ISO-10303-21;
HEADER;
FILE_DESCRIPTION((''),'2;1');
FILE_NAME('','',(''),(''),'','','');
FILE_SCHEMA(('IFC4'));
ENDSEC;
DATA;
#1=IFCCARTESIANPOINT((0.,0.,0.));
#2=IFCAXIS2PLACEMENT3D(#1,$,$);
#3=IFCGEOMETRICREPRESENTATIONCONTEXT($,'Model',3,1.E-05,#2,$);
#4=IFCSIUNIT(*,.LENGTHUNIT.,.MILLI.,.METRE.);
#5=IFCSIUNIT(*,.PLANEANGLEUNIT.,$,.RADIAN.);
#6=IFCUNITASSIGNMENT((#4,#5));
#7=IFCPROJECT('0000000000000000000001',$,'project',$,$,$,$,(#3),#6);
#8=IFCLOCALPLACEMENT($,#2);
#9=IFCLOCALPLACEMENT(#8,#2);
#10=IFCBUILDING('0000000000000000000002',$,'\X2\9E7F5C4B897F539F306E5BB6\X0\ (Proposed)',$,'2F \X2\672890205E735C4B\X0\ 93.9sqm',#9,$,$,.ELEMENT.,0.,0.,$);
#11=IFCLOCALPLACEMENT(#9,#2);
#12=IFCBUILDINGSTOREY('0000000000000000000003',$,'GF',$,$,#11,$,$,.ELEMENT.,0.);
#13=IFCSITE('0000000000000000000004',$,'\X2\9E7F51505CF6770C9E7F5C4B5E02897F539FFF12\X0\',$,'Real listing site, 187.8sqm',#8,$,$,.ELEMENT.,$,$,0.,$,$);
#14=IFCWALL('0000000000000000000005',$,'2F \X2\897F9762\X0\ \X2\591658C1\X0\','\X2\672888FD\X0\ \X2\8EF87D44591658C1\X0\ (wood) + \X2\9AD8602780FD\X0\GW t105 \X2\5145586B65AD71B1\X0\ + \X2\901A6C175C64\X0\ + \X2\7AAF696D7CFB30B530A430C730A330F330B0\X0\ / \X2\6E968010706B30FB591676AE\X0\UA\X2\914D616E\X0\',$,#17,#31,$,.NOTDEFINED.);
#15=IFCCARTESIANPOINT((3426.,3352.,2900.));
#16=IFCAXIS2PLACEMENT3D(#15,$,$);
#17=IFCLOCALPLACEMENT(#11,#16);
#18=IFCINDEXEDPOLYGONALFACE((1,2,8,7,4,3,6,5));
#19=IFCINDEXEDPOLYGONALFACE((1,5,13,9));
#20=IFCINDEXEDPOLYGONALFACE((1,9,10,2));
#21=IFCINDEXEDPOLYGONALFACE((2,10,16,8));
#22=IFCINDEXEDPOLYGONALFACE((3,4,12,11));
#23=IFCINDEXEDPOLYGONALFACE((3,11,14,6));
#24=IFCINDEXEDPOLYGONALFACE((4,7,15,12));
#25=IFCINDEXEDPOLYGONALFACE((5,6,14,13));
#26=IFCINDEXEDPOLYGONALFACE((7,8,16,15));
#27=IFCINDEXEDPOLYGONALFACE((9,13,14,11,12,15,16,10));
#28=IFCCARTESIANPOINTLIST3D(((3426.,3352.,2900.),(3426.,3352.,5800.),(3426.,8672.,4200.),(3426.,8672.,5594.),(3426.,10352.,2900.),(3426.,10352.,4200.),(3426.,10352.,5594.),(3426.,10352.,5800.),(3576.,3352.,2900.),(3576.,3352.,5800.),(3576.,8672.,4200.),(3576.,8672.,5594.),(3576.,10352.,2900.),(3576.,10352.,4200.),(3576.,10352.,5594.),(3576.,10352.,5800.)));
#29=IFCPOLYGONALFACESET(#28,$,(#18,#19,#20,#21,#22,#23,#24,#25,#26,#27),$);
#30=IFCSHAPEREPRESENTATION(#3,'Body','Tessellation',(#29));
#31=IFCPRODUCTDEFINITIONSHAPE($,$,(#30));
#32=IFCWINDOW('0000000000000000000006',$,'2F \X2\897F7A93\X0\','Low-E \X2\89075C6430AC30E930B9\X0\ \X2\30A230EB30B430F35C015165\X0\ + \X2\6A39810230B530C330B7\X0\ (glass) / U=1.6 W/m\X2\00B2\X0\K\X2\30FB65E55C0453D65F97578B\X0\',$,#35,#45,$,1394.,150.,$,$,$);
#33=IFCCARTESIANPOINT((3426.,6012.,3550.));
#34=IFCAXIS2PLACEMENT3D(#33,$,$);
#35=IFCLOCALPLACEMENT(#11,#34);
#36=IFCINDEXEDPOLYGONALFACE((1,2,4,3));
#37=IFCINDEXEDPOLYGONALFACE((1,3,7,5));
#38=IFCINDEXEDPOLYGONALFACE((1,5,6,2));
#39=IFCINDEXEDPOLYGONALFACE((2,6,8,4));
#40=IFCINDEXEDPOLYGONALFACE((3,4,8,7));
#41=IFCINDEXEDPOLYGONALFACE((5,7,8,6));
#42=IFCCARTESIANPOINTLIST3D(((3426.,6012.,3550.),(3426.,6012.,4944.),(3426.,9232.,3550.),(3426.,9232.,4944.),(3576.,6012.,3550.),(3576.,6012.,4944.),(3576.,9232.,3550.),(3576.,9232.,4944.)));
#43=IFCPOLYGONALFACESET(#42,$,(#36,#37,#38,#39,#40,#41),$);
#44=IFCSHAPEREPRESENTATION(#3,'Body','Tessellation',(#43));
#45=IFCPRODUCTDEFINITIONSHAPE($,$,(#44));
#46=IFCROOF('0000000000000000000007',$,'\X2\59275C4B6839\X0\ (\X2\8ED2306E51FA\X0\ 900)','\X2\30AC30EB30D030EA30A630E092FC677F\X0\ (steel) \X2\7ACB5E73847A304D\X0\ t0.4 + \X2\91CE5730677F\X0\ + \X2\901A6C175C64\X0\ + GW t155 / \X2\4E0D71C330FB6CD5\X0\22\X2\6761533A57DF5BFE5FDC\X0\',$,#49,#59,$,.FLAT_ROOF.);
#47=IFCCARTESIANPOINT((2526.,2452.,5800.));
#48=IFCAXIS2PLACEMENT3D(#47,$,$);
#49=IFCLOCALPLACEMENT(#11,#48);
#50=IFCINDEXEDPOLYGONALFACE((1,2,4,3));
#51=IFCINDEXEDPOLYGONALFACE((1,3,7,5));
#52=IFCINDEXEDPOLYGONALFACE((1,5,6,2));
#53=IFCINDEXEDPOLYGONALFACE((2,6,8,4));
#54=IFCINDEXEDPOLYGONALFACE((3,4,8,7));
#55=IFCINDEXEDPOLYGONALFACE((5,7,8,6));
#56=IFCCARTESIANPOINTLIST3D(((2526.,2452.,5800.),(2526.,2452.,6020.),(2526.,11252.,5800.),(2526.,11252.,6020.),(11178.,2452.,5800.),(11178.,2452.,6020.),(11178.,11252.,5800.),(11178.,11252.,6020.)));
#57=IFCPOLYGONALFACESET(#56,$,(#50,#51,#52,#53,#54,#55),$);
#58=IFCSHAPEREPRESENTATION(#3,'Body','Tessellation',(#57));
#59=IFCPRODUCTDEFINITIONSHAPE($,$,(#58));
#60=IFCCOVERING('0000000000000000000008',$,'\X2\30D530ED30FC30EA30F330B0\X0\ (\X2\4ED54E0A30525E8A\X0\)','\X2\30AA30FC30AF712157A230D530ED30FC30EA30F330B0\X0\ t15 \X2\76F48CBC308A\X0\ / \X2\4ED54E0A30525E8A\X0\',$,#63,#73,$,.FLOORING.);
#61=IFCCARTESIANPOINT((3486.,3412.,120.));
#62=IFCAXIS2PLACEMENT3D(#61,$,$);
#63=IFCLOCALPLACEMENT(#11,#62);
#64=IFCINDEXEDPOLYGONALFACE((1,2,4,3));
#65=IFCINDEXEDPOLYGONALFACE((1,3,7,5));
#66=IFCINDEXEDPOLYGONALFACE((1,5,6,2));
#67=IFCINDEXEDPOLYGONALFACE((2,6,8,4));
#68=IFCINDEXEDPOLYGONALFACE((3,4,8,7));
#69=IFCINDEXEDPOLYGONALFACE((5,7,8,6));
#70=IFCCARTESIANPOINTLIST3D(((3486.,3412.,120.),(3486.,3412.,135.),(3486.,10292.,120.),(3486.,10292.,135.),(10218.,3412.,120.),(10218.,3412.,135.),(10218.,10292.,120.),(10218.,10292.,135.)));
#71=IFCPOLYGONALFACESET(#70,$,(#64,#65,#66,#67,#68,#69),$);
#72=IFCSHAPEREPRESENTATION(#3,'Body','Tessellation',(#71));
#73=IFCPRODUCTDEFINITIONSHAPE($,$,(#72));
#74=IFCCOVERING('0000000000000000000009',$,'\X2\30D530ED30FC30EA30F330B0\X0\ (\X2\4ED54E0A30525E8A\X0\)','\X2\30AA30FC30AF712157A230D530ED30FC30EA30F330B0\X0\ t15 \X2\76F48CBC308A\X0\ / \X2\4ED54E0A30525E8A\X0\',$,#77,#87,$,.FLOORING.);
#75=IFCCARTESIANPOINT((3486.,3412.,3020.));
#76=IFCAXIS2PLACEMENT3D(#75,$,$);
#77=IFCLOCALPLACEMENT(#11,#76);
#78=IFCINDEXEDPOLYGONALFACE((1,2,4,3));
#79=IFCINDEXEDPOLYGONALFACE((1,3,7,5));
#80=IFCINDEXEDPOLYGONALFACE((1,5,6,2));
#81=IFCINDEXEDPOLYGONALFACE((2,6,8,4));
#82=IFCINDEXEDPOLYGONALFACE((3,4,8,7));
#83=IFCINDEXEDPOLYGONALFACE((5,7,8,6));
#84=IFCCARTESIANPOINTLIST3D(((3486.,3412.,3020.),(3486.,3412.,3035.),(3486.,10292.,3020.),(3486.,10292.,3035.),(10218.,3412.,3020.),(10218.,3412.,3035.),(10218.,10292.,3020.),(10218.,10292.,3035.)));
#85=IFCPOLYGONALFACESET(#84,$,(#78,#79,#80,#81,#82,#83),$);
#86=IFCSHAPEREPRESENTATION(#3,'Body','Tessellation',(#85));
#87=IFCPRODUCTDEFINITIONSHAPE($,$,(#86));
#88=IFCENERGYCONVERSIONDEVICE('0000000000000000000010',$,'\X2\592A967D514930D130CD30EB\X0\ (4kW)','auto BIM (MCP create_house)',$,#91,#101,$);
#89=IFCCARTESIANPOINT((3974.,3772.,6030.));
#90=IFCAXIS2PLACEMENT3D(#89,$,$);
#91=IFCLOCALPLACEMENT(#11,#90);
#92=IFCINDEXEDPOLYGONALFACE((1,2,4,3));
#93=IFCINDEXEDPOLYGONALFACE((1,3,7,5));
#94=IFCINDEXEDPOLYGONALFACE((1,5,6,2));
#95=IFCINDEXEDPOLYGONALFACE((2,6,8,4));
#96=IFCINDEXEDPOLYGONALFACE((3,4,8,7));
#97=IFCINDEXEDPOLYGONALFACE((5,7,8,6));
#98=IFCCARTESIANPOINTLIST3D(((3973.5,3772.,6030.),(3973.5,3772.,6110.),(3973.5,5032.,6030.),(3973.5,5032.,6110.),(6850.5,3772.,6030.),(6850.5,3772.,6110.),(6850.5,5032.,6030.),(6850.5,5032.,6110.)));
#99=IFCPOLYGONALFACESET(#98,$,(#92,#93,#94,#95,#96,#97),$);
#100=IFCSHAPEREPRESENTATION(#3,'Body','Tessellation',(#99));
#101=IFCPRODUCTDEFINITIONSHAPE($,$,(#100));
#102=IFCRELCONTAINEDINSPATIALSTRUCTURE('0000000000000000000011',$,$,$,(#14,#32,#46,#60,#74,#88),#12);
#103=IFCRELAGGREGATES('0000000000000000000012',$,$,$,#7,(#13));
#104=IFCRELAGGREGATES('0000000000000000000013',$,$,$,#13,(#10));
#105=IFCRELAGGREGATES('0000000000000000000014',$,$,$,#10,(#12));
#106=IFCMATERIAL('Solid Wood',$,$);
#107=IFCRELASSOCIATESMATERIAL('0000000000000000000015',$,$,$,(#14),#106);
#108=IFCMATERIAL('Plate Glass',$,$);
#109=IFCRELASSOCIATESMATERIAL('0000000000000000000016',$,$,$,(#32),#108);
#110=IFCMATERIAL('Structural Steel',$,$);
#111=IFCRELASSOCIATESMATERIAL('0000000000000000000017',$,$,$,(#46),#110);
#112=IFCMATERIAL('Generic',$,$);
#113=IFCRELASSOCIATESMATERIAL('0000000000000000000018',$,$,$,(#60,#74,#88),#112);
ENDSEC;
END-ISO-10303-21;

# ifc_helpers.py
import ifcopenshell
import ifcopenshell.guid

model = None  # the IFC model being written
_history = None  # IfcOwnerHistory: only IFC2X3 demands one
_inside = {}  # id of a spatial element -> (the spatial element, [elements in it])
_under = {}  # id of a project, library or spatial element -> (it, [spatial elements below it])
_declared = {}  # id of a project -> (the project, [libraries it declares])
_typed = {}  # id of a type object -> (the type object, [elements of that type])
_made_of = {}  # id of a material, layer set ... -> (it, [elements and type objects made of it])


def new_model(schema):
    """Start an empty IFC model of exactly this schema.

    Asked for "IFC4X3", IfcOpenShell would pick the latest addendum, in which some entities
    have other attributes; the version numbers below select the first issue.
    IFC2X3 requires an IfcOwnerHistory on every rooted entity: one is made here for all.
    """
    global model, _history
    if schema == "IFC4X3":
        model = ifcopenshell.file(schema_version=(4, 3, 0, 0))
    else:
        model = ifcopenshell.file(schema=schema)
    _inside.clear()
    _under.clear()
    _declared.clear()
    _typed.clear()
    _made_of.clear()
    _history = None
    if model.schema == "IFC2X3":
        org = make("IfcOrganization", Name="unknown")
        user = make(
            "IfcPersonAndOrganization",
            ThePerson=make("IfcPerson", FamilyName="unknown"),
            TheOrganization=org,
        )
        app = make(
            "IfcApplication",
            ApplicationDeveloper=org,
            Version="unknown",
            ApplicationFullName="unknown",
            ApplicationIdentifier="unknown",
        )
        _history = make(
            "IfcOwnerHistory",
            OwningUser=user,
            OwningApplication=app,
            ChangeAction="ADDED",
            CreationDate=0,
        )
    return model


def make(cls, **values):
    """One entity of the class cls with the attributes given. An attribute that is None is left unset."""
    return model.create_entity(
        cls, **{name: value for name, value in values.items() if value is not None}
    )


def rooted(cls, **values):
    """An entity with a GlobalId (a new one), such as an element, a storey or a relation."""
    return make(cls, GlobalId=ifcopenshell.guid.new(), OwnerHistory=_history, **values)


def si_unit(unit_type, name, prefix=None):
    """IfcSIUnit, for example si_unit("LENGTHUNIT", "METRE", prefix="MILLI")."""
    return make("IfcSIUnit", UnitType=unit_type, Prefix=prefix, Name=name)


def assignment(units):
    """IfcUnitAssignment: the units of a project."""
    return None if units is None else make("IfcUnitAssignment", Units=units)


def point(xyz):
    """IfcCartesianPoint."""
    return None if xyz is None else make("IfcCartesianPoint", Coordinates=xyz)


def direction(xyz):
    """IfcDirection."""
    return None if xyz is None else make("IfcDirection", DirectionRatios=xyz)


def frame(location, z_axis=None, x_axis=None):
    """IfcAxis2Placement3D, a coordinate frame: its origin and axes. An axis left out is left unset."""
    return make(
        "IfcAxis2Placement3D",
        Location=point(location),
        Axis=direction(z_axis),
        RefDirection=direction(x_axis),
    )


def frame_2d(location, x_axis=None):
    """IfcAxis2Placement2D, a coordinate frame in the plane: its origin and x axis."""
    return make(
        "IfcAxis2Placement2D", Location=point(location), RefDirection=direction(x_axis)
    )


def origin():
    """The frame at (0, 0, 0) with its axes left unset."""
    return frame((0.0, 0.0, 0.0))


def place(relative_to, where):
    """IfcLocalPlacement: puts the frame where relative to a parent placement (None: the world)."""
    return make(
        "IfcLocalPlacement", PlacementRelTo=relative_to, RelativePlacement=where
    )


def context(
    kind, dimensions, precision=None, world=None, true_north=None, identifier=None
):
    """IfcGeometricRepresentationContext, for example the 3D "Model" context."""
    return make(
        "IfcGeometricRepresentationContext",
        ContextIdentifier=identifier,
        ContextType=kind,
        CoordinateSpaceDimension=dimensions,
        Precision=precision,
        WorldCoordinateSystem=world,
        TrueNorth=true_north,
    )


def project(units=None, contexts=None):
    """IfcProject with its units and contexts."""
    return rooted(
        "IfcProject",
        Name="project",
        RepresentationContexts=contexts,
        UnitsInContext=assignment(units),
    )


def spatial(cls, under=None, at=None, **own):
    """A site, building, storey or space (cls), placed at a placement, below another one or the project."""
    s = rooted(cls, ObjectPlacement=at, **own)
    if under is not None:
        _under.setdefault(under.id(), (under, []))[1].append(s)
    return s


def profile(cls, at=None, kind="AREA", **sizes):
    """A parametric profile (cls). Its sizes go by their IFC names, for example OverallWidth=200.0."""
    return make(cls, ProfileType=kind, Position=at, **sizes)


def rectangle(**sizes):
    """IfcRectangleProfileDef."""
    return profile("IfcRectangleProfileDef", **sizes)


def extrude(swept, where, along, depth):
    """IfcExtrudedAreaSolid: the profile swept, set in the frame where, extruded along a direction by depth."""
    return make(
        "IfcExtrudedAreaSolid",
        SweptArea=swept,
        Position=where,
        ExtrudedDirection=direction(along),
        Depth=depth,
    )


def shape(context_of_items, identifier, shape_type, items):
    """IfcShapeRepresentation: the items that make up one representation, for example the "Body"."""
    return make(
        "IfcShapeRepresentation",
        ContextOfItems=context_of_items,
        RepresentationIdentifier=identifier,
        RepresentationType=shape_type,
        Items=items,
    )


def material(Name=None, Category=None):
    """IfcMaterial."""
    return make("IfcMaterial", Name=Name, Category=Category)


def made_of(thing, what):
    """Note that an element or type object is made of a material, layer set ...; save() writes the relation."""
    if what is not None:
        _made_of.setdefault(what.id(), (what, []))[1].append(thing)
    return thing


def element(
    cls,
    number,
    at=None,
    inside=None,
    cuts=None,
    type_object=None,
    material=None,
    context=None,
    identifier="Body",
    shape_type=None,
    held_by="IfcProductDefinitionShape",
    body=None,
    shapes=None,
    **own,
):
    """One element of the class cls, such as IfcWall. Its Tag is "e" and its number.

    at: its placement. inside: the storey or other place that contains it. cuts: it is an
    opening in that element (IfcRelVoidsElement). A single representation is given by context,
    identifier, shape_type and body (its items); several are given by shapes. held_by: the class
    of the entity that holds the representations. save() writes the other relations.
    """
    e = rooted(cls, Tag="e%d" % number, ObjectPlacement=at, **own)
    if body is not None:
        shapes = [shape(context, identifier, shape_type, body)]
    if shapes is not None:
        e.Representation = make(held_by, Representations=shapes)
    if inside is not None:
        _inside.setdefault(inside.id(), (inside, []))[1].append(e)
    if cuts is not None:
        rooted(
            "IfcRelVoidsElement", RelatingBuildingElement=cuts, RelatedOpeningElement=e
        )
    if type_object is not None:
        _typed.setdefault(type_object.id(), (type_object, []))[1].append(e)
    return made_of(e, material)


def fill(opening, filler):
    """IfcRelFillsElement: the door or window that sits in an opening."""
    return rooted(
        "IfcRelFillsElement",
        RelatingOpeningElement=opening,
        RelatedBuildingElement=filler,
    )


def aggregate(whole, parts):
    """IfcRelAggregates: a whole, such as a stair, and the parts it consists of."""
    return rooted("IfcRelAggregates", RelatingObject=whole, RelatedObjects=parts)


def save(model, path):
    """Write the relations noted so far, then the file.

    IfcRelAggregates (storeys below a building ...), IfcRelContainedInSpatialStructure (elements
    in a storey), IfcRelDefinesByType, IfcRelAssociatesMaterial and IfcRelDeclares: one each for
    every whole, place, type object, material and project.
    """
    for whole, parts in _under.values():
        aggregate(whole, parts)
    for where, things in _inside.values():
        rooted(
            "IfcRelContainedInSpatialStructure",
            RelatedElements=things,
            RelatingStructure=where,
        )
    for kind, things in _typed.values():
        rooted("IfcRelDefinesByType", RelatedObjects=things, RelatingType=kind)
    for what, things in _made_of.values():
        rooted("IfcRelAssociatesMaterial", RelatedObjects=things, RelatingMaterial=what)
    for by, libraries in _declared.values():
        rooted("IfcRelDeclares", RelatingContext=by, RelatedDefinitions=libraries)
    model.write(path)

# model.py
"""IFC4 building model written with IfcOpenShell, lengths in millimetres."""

from ifc_helpers import new_model, si_unit, frame, frame_2d, origin, place, context, project, spatial, rectangle, extrude, material, element, fill, save


model = new_model("IFC4")

# Units and contexts
model_context = context("Model", 3, precision=1e-05, world=origin())
ifc_project = project(units=[si_unit("LENGTHUNIT", "METRE", prefix="MILLI"), si_unit("PLANEANGLEUNIT", "RADIAN")], contexts=[model_context])

# Site, building, storey
site_placement = place(None, origin())
site = spatial("IfcSite", under=ifc_project, at=site_placement, Name="鹿児島県鹿屋市西原２", ObjectType="Real listing site, 187.8sqm", CompositionType="ELEMENT", RefElevation=0.0)
building_placement = place(site_placement, origin())
building = spatial("IfcBuilding", under=site, at=building_placement, Name="鹿屋西原の家 (Proposed)", ObjectType="2F 木造平屋 93.9sqm", CompositionType="ELEMENT", ElevationOfRefHeight=0.0, ElevationOfTerrain=0.0)
storey_placement = place(building_placement, origin())
storey = spatial("IfcBuildingStorey", under=building, at=storey_placement, Name="GF", CompositionType="ELEMENT", Elevation=0.0)

# Shared definitions
ifc_material_1 = material(Name="Solid Wood")

# Shared definitions
ifc_material_2 = material(Name="Plate Glass")

# Wall, opening, window
wall_1_placement = place(storey_placement, frame((3426.0, 3352.0, 2900.0)))
wall_1 = element("IfcWall", 1, at=wall_1_placement, inside=storey, material=ifc_material_1, Name="2F 西面 外壁", Description="木製 軸組外壁 (wood) + 高性能GW t105 充填断熱 + 通気層 + 窯業系サイディング / 準耐火・外皮UA配慮", PredefinedType="NOTDEFINED", context=model_context, shape_type="SweptSolid", body=[
    extrude(rectangle(XDim=150.0, YDim=7000.0, at=frame_2d((75.0, 3500.0))), frame((3426.0, 3352.0, 2900.0)), (0.0, 0.0, 1.0), 2900.0),
])
opening_1_placement = place(storey_placement, frame((3426.0, 6012.0, 3550.0)))
opening_1 = element("IfcOpeningElement", 2, at=opening_1_placement, cuts=wall_1, PredefinedType="NOTDEFINED", context=model_context, shape_type="SweptSolid", body=[
    extrude(rectangle(XDim=150.0, YDim=3220.0, at=frame_2d((75.0, 1610.0))), frame((3426.0, 6012.0, 3550.0)), (0.0, 0.0, 1.0), 1394.0),
])
window_1_placement = place(storey_placement, frame((3426.0, 6012.0, 3550.0)))
window_1 = element("IfcWindow", 3, at=window_1_placement, inside=storey, material=ifc_material_2, Name="2F 西窓", Description="Low-E 複層ガラス アルゴン封入 + 樹脂サッシ (glass) / U=1.6 W/m²K・日射取得型", OverallHeight=1394.0, OverallWidth=150.0, context=model_context, shape_type="SweptSolid", body=[
    extrude(rectangle(XDim=150.0, YDim=3220.0, at=frame_2d((75.0, 1610.0))), frame((3426.0, 6012.0, 3550.0)), (0.0, 0.0, 1.0), 1394.0),
])
fill(opening_1, window_1)

# Roof
ifc_material_3 = material(Name="Structural Steel")
roof_placement = place(storey_placement, frame((2526.0, 2452.0, 5800.0)))
element("IfcRoof", 4, at=roof_placement, inside=storey, material=ifc_material_3, Name="大屋根 (軒の出 900)", Description="ガルバリウム鋼板 (steel) 立平葺き t0.4 + 野地板 + 通気層 + GW t155 / 不燃・法22条区域対応", PredefinedType="FLAT_ROOF", context=model_context, shape_type="SweptSolid", body=[
    extrude(rectangle(XDim=8652.0, YDim=8800.0, at=frame_2d((4326.0, 4400.0))), frame((2526.0, 2452.0, 5800.0)), (0.0, 0.0, 1.0), 220.0),
])

# Coverings
ifc_material_4 = material(Name="Generic")
covering_1_placement = place(storey_placement, frame((3486.0, 3412.0, 120.0)))
element("IfcCovering", 5, at=covering_1_placement, inside=storey, material=ifc_material_4, Name="フローリング (仕上げ床)", Description="オーク無垢フローリング t15 直貼り / 仕上げ床", PredefinedType="FLOORING", context=model_context, shape_type="SweptSolid", body=[
    extrude(rectangle(XDim=6732.0, YDim=6880.0, at=frame_2d((3366.0, 3440.0))), frame((3486.0, 3412.0, 120.0)), (0.0, 0.0, 1.0), 15.0),
])
covering_2_placement = place(storey_placement, frame((3486.0, 3412.0, 3020.0)))
element("IfcCovering", 6, at=covering_2_placement, inside=storey, material=ifc_material_4, Name="フローリング (仕上げ床)", Description="オーク無垢フローリング t15 直貼り / 仕上げ床", PredefinedType="FLOORING", context=model_context, shape_type="SweptSolid", body=[
    extrude(rectangle(XDim=6732.0, YDim=6880.0, at=frame_2d((3366.0, 3440.0))), frame((3486.0, 3412.0, 3020.0)), (0.0, 0.0, 1.0), 15.0),
])

# Energy conversion device
energy_conversion_device_placement = place(storey_placement, frame((3974.0, 3772.0, 6030.0)))
element("IfcEnergyConversionDevice", 7, at=energy_conversion_device_placement, inside=storey, material=ifc_material_4, Name="太陽光パネル (4kW)", Description="auto BIM (MCP create_house)", context=model_context, shape_type="SweptSolid", body=[
    extrude(rectangle(XDim=2877.0, YDim=1260.0, at=frame_2d((1438.0, 630.0))), frame((3974.0, 3772.0, 6030.0)), (0.0, 0.0, 1.0), 80.0),
])

save(model, "model.ifc")
